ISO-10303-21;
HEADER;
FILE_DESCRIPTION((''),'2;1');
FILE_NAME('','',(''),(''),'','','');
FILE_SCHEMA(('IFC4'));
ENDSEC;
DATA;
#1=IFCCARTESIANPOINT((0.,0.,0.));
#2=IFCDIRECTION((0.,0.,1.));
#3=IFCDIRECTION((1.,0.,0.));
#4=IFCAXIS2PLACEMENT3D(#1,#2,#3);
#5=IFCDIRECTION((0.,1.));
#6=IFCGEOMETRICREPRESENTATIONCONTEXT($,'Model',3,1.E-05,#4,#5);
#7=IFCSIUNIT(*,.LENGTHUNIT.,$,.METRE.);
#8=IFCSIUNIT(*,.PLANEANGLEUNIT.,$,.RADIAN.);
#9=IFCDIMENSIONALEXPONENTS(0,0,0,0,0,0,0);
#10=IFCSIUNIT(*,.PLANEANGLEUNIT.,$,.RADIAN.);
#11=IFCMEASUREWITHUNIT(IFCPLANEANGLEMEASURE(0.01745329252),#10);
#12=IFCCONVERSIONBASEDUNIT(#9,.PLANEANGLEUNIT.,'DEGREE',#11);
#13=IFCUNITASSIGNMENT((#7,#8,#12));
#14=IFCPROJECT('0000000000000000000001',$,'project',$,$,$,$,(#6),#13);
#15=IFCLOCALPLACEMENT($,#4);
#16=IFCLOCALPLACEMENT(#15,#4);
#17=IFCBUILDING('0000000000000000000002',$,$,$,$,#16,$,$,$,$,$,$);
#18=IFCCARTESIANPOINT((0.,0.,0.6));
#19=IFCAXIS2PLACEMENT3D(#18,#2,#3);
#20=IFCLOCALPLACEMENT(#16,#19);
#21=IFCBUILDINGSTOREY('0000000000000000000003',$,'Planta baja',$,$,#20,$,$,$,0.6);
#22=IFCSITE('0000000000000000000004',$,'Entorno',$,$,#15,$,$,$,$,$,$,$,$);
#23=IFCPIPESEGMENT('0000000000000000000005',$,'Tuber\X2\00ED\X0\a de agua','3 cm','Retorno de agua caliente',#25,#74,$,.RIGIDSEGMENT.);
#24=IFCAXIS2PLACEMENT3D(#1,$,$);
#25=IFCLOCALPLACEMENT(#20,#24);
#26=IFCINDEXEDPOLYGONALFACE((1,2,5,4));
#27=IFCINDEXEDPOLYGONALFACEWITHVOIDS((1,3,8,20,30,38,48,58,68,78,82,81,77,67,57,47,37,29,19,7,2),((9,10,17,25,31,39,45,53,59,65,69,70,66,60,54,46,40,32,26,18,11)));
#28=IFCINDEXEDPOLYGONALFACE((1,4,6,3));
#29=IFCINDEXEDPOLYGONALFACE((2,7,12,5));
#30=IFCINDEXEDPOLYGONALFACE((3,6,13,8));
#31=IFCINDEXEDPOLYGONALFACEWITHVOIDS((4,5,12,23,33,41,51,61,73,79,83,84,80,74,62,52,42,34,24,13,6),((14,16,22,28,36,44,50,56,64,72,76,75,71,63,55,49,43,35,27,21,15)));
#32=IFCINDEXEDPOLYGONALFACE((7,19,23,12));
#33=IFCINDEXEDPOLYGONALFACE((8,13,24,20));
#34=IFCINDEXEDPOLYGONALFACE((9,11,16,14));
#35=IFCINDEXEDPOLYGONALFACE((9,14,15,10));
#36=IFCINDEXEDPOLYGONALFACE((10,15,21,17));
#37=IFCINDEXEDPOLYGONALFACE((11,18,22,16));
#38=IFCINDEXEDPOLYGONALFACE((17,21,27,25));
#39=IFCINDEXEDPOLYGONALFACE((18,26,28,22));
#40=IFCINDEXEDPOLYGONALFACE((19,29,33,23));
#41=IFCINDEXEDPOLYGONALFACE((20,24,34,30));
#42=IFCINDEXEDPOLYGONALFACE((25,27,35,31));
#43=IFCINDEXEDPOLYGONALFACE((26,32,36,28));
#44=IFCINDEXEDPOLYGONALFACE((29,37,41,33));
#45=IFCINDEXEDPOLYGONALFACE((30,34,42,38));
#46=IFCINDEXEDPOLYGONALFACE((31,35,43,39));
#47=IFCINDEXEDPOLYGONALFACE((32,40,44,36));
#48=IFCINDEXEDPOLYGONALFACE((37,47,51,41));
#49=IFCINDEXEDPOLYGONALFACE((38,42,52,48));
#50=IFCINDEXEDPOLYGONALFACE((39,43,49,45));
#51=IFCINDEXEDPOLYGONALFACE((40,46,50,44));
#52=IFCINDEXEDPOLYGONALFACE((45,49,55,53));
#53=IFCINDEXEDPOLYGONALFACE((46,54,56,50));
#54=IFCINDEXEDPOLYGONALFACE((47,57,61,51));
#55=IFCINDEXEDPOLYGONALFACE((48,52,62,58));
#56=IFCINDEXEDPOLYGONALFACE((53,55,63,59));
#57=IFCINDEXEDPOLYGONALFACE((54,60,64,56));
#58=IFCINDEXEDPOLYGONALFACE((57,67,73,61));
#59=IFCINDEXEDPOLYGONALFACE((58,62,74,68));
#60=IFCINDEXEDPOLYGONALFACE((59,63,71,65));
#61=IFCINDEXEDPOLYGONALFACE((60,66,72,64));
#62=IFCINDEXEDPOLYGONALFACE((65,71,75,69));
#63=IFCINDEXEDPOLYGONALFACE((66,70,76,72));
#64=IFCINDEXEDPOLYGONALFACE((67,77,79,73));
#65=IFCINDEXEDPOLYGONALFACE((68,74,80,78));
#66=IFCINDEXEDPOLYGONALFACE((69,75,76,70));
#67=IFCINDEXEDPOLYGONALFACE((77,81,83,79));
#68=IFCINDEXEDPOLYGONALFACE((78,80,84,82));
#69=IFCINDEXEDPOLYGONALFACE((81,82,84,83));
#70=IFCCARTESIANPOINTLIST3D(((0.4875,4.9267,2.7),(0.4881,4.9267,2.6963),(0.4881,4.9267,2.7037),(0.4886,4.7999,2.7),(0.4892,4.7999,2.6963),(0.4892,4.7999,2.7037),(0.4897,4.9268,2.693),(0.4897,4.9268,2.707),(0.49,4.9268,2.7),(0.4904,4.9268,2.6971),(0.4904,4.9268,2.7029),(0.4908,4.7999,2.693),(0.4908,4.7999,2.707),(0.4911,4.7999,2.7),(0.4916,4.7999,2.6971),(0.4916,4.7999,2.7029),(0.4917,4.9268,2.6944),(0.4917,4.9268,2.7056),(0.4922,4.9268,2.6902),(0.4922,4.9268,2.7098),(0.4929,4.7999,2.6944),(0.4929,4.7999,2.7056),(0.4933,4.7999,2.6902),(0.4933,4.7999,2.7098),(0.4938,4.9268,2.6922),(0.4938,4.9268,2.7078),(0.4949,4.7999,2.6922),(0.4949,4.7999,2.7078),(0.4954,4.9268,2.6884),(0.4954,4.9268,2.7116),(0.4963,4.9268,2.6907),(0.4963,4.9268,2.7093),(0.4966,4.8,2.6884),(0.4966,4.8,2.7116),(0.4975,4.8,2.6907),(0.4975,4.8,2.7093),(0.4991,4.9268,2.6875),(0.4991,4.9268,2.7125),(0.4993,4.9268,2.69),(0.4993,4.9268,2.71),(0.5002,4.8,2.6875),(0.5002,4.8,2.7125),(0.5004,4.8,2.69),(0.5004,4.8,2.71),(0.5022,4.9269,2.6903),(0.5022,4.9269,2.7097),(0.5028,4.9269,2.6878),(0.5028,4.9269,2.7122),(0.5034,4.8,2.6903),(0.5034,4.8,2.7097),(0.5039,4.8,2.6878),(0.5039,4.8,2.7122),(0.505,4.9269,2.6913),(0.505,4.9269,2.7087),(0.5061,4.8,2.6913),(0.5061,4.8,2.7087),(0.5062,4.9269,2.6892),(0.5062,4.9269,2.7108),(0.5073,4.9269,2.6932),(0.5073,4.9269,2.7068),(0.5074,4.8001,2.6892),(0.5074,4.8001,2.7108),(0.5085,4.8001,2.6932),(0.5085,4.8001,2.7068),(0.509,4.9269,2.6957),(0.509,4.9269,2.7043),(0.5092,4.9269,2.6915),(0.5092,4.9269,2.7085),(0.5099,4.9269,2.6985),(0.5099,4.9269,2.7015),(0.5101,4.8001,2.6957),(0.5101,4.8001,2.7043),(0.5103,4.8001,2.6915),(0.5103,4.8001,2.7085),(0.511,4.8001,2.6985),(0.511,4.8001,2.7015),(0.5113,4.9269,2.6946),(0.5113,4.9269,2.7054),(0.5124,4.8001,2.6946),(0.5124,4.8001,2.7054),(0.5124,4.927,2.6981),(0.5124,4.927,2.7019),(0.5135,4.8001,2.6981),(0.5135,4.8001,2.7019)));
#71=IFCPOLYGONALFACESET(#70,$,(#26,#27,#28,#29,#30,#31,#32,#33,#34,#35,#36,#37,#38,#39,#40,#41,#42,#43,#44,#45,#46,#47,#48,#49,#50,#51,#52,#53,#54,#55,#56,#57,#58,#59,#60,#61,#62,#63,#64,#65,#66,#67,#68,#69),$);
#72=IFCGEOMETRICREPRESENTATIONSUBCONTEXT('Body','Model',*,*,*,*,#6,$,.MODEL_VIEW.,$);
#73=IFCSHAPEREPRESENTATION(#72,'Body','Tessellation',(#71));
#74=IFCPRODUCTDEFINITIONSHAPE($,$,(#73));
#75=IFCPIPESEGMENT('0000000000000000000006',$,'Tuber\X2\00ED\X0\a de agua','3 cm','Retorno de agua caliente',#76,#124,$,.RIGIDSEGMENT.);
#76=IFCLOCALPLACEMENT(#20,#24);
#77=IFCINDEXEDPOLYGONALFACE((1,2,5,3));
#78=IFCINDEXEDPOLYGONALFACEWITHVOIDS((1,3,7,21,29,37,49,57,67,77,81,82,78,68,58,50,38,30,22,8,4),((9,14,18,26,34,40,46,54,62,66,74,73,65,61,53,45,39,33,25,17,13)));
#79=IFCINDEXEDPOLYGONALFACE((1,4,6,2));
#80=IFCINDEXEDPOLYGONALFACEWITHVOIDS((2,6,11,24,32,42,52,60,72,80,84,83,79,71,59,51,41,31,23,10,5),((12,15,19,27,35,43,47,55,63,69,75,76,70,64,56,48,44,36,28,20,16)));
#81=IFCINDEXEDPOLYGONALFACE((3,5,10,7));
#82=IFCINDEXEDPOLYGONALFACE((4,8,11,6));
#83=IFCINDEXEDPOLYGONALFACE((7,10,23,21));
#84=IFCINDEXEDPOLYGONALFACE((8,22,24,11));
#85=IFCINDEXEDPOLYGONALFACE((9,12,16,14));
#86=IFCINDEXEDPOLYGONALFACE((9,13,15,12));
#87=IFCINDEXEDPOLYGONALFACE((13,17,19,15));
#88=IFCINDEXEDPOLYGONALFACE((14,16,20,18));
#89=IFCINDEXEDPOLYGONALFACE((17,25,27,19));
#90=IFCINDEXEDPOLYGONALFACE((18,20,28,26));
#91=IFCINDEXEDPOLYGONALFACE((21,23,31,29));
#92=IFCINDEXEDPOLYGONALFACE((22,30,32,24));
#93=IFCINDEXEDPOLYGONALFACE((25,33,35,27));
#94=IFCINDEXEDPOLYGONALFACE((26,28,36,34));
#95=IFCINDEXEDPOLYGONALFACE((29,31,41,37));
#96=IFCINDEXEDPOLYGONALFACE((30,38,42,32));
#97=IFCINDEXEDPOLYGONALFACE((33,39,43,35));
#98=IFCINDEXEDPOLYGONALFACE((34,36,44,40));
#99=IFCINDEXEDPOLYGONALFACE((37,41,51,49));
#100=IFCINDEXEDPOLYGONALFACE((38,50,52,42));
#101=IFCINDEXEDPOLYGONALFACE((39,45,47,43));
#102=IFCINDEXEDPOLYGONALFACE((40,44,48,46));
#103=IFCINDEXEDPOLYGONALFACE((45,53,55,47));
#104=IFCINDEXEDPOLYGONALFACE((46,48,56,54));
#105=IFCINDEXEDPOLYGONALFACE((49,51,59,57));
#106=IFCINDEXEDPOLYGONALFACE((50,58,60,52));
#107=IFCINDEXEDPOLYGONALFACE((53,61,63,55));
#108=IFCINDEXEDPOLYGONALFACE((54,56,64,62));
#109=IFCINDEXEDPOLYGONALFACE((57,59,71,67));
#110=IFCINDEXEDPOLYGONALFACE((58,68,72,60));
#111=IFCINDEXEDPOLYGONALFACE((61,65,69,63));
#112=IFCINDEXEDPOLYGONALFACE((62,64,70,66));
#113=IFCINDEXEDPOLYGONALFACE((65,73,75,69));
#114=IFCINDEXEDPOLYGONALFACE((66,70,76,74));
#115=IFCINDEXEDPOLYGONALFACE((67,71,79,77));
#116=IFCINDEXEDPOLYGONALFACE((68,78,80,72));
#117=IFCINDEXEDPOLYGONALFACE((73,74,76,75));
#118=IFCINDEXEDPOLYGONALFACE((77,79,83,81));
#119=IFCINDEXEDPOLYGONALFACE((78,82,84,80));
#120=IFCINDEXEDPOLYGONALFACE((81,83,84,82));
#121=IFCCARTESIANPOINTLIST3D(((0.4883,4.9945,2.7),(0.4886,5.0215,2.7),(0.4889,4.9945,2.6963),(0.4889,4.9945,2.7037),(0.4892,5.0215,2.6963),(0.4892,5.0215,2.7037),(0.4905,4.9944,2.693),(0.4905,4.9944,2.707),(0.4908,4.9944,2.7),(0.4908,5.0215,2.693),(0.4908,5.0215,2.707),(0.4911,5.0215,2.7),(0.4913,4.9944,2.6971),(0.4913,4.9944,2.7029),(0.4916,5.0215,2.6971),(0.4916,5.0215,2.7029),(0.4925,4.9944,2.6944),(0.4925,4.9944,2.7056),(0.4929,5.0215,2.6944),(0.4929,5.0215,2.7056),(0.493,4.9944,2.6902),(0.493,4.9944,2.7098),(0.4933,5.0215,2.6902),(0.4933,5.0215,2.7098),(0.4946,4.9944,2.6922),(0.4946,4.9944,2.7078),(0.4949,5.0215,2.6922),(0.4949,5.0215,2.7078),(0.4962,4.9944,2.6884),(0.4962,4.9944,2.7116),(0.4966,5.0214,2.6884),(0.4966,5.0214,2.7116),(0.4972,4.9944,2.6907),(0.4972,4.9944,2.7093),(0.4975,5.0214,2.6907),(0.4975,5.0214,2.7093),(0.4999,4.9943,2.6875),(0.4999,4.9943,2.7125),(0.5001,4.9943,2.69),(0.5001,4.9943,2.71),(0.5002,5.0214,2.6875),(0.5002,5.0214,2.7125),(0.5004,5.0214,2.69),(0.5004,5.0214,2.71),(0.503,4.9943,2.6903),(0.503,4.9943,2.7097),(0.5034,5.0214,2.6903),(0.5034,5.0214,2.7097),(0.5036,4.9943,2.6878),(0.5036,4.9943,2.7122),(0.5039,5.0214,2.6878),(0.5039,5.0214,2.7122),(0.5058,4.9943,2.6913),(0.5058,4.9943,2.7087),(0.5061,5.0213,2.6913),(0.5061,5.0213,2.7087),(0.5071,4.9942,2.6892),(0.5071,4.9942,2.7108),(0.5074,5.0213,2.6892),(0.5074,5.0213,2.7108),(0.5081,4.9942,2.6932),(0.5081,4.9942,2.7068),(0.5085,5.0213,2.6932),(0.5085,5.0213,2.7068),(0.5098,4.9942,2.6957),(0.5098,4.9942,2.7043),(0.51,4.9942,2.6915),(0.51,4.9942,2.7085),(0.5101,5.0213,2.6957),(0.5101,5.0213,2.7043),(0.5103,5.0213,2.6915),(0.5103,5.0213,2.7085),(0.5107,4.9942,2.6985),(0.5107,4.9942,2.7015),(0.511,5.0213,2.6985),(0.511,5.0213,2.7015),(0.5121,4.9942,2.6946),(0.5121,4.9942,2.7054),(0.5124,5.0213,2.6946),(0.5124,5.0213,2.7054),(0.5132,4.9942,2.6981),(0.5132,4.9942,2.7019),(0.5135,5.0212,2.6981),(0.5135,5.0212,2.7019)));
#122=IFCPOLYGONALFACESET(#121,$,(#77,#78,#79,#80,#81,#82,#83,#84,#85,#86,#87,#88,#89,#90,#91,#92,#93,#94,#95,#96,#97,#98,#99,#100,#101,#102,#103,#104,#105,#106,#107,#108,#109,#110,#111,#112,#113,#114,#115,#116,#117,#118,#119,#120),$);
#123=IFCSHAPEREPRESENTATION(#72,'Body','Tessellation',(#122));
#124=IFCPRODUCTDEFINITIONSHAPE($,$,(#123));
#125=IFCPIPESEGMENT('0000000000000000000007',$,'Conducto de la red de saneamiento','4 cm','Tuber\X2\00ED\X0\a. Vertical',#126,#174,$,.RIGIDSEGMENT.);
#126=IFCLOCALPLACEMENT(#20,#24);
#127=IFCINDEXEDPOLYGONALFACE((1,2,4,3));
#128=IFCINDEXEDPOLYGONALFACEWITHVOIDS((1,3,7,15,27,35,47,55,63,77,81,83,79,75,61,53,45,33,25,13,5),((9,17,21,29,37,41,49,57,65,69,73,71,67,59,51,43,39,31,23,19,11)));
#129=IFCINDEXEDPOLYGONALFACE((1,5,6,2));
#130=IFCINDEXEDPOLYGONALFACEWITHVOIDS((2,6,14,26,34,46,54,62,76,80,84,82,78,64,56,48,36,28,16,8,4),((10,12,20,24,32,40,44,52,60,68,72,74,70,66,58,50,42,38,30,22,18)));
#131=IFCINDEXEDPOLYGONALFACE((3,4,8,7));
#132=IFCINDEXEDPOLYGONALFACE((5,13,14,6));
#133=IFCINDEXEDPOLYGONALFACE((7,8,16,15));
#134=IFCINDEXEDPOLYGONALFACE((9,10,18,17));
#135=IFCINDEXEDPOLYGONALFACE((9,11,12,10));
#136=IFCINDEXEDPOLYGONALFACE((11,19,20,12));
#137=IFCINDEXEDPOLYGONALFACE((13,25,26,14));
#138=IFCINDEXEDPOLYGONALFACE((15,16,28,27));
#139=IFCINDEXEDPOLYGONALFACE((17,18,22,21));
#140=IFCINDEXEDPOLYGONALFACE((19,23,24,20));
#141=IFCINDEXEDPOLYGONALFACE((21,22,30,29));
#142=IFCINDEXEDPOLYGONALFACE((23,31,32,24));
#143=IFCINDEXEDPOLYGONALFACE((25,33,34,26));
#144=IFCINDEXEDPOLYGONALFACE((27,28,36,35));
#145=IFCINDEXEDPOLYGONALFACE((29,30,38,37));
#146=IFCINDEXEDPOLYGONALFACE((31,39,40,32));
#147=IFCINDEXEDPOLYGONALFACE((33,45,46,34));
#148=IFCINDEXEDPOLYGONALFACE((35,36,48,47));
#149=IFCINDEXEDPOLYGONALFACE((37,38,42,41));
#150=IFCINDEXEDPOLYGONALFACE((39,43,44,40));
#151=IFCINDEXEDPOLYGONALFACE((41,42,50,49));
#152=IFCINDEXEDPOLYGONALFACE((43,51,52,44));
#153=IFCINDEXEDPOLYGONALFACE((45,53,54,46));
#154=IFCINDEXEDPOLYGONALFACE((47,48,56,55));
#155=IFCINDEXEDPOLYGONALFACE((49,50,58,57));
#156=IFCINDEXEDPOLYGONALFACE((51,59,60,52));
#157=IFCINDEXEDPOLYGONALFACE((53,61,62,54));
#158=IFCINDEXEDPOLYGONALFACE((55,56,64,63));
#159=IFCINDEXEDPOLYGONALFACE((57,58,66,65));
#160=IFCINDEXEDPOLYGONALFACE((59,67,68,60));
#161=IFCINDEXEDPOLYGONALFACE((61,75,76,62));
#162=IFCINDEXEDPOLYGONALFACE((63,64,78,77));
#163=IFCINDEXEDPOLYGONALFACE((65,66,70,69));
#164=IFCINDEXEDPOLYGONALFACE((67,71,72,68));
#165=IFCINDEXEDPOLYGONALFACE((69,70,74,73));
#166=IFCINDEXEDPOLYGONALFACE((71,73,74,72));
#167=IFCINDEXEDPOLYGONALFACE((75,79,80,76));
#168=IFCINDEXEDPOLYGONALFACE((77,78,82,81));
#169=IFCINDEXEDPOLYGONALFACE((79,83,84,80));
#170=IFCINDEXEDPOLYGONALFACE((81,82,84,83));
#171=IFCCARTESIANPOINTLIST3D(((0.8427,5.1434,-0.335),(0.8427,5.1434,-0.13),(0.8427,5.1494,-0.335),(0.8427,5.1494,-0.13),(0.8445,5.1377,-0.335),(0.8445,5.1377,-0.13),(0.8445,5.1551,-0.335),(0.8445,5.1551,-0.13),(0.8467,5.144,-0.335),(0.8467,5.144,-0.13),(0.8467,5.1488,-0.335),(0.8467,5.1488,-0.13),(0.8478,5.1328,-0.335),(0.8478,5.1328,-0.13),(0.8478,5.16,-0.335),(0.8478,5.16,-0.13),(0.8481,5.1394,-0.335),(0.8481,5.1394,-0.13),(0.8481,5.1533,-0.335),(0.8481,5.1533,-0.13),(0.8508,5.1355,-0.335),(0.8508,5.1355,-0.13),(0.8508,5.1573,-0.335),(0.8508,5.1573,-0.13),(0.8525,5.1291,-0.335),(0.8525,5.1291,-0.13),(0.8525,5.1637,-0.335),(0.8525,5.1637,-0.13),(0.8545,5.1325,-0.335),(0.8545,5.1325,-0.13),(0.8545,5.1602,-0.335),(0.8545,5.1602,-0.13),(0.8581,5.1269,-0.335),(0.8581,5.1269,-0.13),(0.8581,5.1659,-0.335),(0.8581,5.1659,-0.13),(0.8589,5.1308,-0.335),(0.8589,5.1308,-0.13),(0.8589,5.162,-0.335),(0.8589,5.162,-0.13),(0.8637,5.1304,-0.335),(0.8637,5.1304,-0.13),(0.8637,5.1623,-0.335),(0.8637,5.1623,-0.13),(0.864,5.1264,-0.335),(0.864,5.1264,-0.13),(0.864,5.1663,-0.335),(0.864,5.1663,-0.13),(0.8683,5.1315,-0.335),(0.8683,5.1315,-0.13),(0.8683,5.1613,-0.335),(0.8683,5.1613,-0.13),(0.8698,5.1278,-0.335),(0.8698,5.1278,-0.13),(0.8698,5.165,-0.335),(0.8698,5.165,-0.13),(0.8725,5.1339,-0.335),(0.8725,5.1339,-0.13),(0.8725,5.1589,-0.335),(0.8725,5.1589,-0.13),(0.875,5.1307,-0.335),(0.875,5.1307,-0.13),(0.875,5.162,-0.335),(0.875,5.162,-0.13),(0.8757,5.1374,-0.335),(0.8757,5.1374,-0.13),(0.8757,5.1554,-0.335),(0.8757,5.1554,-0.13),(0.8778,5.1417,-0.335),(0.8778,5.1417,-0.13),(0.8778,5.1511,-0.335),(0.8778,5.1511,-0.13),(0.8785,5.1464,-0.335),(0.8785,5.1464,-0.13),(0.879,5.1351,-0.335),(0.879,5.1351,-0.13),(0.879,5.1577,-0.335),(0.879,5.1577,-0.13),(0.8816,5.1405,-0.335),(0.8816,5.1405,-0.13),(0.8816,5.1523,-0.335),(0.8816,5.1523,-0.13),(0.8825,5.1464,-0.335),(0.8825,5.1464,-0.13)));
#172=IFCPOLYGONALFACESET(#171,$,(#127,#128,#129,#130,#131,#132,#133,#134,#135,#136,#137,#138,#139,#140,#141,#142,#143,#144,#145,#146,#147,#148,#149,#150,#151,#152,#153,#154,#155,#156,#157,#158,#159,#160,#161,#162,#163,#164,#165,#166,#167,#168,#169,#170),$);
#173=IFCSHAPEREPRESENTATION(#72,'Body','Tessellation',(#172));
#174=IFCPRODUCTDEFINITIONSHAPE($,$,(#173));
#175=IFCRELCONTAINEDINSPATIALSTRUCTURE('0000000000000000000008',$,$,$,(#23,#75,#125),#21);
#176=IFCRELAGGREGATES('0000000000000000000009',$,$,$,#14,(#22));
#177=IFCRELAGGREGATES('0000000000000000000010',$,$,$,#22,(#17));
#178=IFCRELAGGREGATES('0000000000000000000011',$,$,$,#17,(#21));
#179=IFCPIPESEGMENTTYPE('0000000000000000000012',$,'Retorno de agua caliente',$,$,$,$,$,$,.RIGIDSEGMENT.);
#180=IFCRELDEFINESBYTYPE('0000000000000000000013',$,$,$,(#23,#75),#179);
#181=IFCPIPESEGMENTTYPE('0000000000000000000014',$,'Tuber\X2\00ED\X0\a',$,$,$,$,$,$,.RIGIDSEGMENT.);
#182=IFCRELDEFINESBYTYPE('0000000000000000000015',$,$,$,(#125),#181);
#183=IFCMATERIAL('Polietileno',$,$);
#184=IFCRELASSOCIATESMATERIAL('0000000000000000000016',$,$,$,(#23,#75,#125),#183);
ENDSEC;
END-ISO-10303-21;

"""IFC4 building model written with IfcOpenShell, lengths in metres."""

from ifc_helpers import new_model, entity, si_unit, converted_unit, direction, frame, origin_with_axes, origin_2d_with_axis, place, context, subcontext, project, spatial, hollow_circle, extrude, material, type_object, element, save


model = new_model("IFC4")

# Units and contexts
model_context = context("Model", 3, precision=1e-05, world=origin_with_axes(), true_north=direction((0.0, 1.0)))
body_context = subcontext(model_context, "Body", "Model", "MODEL_VIEW")
ifc_project = project(units=[si_unit("LENGTHUNIT", "METRE"), si_unit("PLANEANGLEUNIT", "RADIAN"), converted_unit("PLANEANGLEUNIT", "DEGREE", entity("IfcPlaneAngleMeasure", 0.01745329252), si_unit("PLANEANGLEUNIT", "RADIAN"), dimensions=[0, 0, 0, 0, 0, 0, 0])], contexts=[model_context])

# Site, building, storey
site_placement = place(None, origin_with_axes())
site = spatial("IfcSite", under=ifc_project, at=site_placement, Name="Entorno")
building_placement = place(site_placement, origin_with_axes())
building = spatial("IfcBuilding", under=site, at=building_placement)
storey_placement = place(building_placement, frame((0.0, 0.0, 0.6), z_axis=(0.0, 0.0, 1.0), x_axis=(1.0, 0.0, 0.0)))
storey = spatial("IfcBuildingStorey", under=building, at=storey_placement, Name="Planta baja", Elevation=0.6)

# Pipe segments
ifc_material_1 = material(Name="Polietileno")
pipe_segment_type_1 = type_object("IfcPipeSegmentType", Name="Retorno de agua caliente", PredefinedType="RIGIDSEGMENT")
pipe_segment_1_placement = place(storey_placement, frame((0.5011, 4.8, 2.7), z_axis=(-0.008946, 0.99996, 0.0), x_axis=(-0.99996, -0.008946, 0.0)))
element("IfcPipeSegment", 1, at=pipe_segment_1_placement, inside=storey, type_object=pipe_segment_type_1, material=ifc_material_1, Name="Tubería de agua", Description="3 cm", ObjectType="Retorno de agua caliente", PredefinedType="RIGIDSEGMENT", context=body_context, shape_type="SweptSolid", body=[
    extrude(hollow_circle(Radius=0.0125, WallThickness=0.0025, at=origin_2d_with_axis()), origin_with_axes(), (0.0, 0.0, 1.0), 0.1268),
])
pipe_segment_2_placement = place(storey_placement, frame((0.5008, 4.9943, 2.7), z_axis=(0.012002, 0.999928, 0.0), x_axis=(-0.999928, 0.012002, 0.0)))
element("IfcPipeSegment", 2, at=pipe_segment_2_placement, inside=storey, type_object=pipe_segment_type_1, material=ifc_material_1, Name="Tubería de agua", Description="3 cm", ObjectType="Retorno de agua caliente", PredefinedType="RIGIDSEGMENT", context=body_context, shape_type="SweptSolid", body=[
    extrude(hollow_circle(Radius=0.0125, WallThickness=0.0025, at=origin_2d_with_axis()), origin_with_axes(), (0.0, 0.0, 1.0), 0.0271),
])
pipe_segment_type_2 = type_object("IfcPipeSegmentType", Name="Tubería", PredefinedType="RIGIDSEGMENT")
pipe_segment_3_placement = place(storey_placement, frame((0.8625, 5.1464, -0.335), z_axis=(0.0, 0.0, 1.0), x_axis=(1.0, 0.0, 0.0)))
element("IfcPipeSegment", 3, at=pipe_segment_3_placement, inside=storey, type_object=pipe_segment_type_2, material=ifc_material_1, Name="Conducto de la red de saneamiento", Description="4 cm", ObjectType="Tubería. Vertical", PredefinedType="RIGIDSEGMENT", context=body_context, shape_type="SweptSolid", body=[
    extrude(hollow_circle(Radius=0.02, WallThickness=0.004, at=origin_2d_with_axis()), origin_with_axes(), (0.0, 0.0, 1.0), 0.205),
])

save(model, "model.ifc")
